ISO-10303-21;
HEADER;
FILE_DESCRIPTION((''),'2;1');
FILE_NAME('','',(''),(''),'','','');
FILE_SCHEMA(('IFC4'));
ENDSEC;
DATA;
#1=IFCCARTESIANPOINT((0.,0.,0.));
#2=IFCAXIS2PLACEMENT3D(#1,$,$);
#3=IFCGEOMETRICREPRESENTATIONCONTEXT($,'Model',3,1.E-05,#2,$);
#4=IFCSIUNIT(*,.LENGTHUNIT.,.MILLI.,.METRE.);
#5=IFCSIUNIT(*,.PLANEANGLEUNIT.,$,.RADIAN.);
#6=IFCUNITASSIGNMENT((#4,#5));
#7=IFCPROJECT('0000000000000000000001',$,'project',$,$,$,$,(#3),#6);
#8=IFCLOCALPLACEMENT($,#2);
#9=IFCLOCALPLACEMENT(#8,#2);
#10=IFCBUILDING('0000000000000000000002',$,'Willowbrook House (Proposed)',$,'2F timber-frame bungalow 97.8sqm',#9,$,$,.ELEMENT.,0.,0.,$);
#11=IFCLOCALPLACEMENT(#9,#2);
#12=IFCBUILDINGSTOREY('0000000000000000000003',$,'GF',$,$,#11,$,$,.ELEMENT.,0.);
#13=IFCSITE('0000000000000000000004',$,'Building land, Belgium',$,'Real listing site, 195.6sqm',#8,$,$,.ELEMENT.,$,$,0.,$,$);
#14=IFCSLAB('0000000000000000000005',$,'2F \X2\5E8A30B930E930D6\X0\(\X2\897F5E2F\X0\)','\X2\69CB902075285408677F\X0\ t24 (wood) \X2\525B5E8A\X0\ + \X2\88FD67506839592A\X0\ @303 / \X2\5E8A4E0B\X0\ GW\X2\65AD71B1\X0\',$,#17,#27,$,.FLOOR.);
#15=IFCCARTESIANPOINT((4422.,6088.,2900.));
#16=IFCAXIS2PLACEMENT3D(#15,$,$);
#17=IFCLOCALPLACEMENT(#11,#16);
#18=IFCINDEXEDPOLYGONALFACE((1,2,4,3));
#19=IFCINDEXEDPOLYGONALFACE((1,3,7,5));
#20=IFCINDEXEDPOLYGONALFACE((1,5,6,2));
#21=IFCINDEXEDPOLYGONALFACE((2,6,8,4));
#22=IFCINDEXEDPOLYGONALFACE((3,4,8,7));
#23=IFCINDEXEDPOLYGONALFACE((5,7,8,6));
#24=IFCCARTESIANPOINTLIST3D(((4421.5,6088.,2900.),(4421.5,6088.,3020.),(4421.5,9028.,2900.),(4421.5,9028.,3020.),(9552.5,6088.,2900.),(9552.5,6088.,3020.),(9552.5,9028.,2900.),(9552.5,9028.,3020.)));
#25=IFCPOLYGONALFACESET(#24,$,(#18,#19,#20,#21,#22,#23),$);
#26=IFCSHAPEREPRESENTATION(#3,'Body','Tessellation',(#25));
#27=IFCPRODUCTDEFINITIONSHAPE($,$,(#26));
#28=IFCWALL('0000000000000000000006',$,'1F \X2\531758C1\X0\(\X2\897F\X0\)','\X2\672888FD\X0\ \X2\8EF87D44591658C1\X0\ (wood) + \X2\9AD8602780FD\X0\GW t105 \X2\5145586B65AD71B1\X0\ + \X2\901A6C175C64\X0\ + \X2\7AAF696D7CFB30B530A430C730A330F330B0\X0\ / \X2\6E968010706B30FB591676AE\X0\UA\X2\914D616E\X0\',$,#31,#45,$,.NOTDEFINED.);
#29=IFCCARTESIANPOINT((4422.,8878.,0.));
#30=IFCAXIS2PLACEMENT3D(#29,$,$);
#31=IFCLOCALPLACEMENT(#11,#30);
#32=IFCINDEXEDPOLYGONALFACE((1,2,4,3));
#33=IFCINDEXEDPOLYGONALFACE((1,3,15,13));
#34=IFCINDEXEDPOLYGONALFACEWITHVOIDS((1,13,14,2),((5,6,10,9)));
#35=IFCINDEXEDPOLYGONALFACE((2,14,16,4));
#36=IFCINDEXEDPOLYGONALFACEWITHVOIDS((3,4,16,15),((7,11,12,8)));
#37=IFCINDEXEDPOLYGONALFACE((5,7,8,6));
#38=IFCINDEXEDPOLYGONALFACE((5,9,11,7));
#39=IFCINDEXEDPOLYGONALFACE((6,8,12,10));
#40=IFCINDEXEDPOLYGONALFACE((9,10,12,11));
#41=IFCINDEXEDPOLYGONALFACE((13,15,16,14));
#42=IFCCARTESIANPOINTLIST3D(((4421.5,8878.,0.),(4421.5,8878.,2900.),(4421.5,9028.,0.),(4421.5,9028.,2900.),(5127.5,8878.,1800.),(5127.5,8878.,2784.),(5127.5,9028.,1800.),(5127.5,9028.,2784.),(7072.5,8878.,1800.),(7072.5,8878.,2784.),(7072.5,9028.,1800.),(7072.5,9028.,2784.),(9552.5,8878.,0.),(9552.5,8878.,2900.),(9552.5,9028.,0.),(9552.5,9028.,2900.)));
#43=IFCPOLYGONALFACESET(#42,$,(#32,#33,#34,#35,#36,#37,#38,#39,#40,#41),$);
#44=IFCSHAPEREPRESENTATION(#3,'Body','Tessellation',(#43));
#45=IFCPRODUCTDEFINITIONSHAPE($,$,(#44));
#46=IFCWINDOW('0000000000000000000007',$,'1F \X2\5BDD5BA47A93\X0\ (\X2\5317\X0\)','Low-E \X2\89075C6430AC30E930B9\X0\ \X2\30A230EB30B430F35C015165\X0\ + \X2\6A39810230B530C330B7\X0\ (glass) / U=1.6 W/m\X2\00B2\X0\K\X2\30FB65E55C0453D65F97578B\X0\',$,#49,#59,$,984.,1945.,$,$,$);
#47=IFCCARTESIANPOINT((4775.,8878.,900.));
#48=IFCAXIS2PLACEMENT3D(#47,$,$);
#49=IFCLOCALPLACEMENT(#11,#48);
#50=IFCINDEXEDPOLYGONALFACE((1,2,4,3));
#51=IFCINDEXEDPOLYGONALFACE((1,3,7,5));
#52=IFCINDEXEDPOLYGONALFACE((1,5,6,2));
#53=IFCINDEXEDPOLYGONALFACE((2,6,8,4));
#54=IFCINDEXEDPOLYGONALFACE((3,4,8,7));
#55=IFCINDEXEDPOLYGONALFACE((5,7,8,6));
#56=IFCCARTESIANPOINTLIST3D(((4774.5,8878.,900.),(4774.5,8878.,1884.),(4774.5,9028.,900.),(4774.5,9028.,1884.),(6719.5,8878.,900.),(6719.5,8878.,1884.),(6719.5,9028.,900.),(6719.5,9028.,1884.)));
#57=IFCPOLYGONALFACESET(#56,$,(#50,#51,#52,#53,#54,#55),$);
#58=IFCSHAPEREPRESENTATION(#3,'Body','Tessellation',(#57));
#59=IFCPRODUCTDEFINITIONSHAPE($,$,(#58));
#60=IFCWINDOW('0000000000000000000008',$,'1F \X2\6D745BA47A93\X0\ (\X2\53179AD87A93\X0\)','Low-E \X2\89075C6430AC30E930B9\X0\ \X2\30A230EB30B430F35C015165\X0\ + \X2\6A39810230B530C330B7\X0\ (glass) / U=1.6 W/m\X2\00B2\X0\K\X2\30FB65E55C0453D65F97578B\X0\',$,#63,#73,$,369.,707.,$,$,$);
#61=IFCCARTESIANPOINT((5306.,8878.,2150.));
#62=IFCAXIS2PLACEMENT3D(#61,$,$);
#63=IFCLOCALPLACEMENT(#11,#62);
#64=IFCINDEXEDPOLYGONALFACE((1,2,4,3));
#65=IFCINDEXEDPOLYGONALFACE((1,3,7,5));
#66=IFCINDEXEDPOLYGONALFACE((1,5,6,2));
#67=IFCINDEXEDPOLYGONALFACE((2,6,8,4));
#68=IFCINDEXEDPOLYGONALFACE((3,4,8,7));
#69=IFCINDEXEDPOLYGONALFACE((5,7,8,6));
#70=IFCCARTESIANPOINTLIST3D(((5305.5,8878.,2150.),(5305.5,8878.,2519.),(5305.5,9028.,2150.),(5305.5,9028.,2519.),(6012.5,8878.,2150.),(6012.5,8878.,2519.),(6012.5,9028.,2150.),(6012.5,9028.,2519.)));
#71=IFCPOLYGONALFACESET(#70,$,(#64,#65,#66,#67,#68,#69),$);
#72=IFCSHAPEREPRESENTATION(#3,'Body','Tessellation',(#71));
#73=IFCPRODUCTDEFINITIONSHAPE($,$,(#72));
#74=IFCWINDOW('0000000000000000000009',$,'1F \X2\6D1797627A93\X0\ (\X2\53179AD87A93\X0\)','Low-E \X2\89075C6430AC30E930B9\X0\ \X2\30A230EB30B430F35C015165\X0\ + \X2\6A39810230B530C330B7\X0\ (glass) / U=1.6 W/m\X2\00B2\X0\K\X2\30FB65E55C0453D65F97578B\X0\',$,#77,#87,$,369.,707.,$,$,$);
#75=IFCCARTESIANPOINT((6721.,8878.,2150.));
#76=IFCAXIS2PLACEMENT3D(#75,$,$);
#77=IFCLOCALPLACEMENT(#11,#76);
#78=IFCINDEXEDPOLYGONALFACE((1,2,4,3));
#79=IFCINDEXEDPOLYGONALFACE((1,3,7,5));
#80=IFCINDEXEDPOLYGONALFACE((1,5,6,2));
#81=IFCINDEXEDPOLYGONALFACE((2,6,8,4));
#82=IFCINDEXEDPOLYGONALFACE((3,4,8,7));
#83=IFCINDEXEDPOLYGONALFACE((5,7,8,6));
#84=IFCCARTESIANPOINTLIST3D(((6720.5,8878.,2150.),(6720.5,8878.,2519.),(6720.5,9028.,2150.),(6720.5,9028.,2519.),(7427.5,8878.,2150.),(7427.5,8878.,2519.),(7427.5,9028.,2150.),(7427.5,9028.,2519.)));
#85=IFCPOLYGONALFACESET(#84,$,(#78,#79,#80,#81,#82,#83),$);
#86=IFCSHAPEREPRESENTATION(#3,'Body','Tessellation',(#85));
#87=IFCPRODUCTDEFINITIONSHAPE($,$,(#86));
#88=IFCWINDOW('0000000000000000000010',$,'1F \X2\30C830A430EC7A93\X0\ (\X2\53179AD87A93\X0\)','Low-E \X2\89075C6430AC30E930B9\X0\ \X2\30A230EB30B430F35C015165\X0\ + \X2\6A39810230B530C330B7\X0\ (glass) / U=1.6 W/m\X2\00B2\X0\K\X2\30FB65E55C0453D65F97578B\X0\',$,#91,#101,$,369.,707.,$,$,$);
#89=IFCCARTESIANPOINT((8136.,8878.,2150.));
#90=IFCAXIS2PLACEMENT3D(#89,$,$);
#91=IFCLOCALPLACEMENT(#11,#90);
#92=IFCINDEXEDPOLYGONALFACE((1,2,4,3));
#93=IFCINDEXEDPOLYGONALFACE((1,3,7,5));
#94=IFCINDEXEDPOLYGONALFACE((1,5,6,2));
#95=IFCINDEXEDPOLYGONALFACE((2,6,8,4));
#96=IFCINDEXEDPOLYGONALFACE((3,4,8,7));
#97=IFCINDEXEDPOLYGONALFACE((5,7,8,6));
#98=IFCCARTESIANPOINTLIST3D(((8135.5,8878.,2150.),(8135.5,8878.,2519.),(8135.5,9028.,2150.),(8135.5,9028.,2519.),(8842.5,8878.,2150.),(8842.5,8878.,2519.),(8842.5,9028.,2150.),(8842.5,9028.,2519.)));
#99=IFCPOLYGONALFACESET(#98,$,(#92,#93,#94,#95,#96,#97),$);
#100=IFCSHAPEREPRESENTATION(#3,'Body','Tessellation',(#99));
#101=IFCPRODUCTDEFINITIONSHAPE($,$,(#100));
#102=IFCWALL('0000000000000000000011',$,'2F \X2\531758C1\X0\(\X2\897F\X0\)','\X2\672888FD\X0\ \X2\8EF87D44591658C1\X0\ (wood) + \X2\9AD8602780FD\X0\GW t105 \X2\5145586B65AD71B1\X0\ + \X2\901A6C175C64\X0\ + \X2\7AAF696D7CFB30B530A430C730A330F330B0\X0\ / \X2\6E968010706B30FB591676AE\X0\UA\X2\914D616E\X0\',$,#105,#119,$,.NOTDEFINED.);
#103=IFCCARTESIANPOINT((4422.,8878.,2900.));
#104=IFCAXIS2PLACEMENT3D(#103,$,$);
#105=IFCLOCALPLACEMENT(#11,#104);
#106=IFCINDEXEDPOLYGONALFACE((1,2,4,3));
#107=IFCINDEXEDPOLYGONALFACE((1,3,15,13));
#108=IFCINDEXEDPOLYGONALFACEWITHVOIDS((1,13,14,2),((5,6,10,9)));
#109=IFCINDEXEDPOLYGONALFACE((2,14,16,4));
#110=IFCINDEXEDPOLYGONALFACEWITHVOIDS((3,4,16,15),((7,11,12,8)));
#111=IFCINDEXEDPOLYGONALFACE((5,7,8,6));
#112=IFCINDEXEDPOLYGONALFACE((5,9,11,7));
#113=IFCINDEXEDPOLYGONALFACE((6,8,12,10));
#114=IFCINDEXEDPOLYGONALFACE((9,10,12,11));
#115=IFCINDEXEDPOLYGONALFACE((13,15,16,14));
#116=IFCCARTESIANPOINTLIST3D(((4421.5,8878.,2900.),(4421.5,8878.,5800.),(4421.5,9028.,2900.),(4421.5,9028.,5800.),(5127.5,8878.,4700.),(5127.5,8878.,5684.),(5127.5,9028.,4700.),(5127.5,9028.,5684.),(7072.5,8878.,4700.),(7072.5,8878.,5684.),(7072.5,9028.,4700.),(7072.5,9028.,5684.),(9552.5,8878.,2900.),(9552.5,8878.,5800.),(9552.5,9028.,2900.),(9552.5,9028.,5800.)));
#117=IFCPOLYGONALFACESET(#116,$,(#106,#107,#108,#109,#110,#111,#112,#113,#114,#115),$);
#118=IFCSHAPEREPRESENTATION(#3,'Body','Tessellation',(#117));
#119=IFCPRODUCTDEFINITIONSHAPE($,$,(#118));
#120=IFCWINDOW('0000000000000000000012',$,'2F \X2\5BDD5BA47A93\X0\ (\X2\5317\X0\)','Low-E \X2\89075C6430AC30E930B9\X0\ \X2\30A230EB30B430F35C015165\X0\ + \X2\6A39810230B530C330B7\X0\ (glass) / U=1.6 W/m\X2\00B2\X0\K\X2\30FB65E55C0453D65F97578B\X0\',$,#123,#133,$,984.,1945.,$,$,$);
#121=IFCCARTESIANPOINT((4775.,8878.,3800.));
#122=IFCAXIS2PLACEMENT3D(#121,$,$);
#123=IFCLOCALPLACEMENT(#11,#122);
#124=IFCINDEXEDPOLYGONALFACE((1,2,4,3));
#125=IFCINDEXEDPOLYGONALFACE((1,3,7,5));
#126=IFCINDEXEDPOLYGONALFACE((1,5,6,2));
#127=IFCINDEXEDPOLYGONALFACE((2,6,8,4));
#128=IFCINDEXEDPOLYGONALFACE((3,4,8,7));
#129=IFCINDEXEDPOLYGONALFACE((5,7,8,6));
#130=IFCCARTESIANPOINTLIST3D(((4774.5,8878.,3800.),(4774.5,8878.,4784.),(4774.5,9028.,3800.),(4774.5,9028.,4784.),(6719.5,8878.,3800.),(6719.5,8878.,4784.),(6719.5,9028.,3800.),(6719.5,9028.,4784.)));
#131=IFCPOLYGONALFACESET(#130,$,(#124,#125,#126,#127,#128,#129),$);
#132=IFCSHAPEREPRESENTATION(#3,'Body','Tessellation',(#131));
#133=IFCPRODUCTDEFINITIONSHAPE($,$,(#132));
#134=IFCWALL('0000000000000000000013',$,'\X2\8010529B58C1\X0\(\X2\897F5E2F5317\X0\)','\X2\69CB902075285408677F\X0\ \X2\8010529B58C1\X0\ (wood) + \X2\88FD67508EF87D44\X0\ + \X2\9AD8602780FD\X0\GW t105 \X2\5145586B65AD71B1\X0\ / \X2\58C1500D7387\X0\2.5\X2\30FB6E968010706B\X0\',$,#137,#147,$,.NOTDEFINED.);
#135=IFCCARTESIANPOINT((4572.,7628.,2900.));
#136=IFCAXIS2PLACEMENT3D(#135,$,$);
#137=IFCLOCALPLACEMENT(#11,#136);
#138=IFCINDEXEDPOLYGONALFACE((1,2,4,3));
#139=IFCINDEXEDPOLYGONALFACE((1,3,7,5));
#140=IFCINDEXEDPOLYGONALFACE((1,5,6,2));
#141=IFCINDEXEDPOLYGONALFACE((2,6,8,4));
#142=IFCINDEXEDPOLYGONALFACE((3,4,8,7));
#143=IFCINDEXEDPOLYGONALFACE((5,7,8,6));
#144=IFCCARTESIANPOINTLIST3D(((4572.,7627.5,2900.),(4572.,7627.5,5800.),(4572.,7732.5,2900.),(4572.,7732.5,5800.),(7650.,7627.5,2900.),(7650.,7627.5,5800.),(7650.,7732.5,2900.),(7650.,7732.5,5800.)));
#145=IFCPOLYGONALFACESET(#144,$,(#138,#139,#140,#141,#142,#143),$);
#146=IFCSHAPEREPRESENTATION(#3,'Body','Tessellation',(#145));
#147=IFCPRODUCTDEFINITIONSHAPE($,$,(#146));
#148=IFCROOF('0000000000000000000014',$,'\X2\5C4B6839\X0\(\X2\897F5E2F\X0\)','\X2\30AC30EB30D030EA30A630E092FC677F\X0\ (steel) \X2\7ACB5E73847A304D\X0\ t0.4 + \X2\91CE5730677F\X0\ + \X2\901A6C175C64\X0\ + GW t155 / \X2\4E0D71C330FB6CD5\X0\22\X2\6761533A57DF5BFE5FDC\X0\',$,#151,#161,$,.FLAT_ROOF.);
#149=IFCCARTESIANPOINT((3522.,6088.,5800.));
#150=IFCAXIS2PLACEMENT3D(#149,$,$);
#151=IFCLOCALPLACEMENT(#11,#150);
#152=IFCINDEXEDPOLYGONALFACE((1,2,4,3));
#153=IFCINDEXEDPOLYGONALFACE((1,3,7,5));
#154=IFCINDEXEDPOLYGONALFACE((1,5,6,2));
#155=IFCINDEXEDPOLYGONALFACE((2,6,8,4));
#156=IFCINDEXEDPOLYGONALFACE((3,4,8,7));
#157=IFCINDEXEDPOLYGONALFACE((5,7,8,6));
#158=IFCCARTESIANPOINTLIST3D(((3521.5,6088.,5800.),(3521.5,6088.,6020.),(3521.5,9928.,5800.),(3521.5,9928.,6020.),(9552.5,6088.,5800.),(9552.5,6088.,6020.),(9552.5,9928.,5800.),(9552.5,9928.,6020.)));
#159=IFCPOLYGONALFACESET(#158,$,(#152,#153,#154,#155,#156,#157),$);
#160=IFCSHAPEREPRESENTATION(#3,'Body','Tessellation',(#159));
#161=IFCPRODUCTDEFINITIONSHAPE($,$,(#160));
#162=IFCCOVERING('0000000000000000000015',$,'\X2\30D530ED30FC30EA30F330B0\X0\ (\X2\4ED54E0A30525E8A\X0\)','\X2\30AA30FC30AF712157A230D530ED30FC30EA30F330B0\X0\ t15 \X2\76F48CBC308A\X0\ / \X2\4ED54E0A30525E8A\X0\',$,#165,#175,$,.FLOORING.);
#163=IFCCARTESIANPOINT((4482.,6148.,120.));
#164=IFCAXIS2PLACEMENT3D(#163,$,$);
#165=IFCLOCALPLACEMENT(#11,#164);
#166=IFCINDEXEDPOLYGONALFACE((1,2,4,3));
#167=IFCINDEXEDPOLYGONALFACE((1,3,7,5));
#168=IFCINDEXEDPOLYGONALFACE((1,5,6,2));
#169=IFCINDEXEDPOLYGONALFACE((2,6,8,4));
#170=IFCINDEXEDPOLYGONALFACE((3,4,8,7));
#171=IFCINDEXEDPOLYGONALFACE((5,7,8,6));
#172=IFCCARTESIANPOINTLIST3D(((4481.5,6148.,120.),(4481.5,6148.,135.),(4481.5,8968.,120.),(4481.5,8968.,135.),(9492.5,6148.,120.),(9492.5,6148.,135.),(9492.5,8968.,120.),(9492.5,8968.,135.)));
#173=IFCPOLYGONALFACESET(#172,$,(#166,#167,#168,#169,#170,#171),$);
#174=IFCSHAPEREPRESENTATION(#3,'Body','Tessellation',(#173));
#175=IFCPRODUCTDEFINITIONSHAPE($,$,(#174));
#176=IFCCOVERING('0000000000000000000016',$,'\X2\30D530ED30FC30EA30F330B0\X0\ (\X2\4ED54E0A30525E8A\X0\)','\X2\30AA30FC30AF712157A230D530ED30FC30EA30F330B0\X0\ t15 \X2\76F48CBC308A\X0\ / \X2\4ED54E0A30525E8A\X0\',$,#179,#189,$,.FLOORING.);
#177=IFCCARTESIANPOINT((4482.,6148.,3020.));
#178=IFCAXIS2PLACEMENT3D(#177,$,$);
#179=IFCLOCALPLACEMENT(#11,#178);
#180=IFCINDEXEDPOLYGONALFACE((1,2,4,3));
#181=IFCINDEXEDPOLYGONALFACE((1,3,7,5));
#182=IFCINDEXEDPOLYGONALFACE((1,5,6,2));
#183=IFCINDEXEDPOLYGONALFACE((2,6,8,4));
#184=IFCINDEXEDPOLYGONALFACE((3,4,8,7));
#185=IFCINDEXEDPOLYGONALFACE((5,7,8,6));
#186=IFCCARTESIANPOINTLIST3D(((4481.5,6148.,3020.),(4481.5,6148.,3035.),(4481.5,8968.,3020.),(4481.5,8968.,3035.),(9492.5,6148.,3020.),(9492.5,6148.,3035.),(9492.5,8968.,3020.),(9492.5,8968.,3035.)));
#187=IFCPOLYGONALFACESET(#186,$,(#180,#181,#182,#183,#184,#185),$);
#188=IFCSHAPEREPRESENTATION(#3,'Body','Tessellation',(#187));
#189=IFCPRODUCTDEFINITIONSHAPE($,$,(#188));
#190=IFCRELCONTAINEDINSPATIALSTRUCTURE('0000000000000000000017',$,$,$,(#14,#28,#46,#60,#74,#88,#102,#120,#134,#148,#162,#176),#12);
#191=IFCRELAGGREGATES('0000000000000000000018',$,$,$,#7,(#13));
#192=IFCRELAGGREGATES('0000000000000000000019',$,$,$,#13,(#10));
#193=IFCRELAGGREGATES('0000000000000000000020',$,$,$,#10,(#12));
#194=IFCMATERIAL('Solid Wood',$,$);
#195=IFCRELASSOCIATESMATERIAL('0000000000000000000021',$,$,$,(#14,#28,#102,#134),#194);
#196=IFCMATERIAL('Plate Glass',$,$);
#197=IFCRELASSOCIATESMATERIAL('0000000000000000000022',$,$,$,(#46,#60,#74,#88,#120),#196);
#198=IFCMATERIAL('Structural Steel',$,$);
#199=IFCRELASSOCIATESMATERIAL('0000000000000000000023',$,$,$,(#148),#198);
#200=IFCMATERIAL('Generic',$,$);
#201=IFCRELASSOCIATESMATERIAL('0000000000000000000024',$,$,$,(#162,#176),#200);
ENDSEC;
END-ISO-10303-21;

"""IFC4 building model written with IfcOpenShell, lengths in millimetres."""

from ifc_helpers import new_model, si_unit, frame, frame_2d, origin, place, context, project, spatial, rectangle, extrude, material, element, fill, save


model = new_model("IFC4")

# Units and contexts
model_context = context("Model", 3, precision=1e-05, world=origin())
ifc_project = project(units=[si_unit("LENGTHUNIT", "METRE", prefix="MILLI"), si_unit("PLANEANGLEUNIT", "RADIAN")], contexts=[model_context])

# Site, building, storey
site_placement = place(None, origin())
site = spatial("IfcSite", under=ifc_project, at=site_placement, Name="Building land, Belgium", ObjectType="Real listing site, 195.6sqm", CompositionType="ELEMENT", RefElevation=0.0)
building_placement = place(site_placement, origin())
building = spatial("IfcBuilding", under=site, at=building_placement, Name="Willowbrook House (Proposed)", ObjectType="2F timber-frame bungalow 97.8sqm", CompositionType="ELEMENT", ElevationOfRefHeight=0.0, ElevationOfTerrain=0.0)
storey_placement = place(building_placement, origin())
storey = spatial("IfcBuildingStorey", under=building, at=storey_placement, Name="GF", CompositionType="ELEMENT", Elevation=0.0)

# Slab
ifc_material_1 = material(Name="Solid Wood")
slab_1_placement = place(storey_placement, frame((4422.0, 6088.0, 2900.0)))
element("IfcSlab", 1, at=slab_1_placement, inside=storey, material=ifc_material_1, Name="2F 床スラブ(西帯)", Description="構造用合板 t24 (wood) 剛床 + 製材根太 @303 / 床下 GW断熱", PredefinedType="FLOOR", context=model_context, shape_type="SweptSolid", body=[
    extrude(rectangle(XDim=5131.0, YDim=2940.0, at=frame_2d((2565.0, 1470.0))), frame((4422.0, 6088.0, 2900.0)), (0.0, 0.0, 1.0), 120.0),
])

# Wall, openings, windows
wall_1_placement = place(storey_placement, frame((4422.0, 8878.0, 0.0)))
wall_1 = element("IfcWall", 2, at=wall_1_placement, inside=storey, material=ifc_material_1, Name="1F 北壁(西)", Description="木製 軸組外壁 (wood) + 高性能GW t105 充填断熱 + 通気層 + 窯業系サイディング / 準耐火・外皮UA配慮", PredefinedType="NOTDEFINED", context=model_context, shape_type="SweptSolid", body=[
    extrude(rectangle(XDim=5131.0, YDim=150.0, at=frame_2d((2565.0, 75.0))), frame((4422.0, 8878.0, 0.0)), (0.0, 0.0, 1.0), 2900.0),
])
opening_1_placement = place(storey_placement, frame((4775.0, 8878.0, 900.0)))
opening_1 = element("IfcOpeningElement", 3, at=opening_1_placement, cuts=wall_1, PredefinedType="NOTDEFINED", context=model_context, shape_type="SweptSolid", body=[
    extrude(rectangle(XDim=1945.0, YDim=150.0, at=frame_2d((972.0, 75.0))), frame((4775.0, 8878.0, 900.0)), (0.0, 0.0, 1.0), 984.0),
])
opening_2_placement = place(storey_placement, frame((5306.0, 8878.0, 2150.0)))
opening_2 = element("IfcOpeningElement", 4, at=opening_2_placement, cuts=wall_1, PredefinedType="NOTDEFINED", context=model_context, shape_type="SweptSolid", body=[
    extrude(rectangle(XDim=707.0, YDim=150.0, at=frame_2d((353.0, 75.0))), frame((5306.0, 8878.0, 2150.0)), (0.0, 0.0, 1.0), 369.0),
])
opening_3_placement = place(storey_placement, frame((6721.0, 8878.0, 2150.0)))
opening_3 = element("IfcOpeningElement", 5, at=opening_3_placement, cuts=wall_1, PredefinedType="NOTDEFINED", context=model_context, shape_type="SweptSolid", body=[
    extrude(rectangle(XDim=707.0, YDim=150.0, at=frame_2d((353.0, 75.0))), frame((6721.0, 8878.0, 2150.0)), (0.0, 0.0, 1.0), 369.0),
])
opening_4_placement = place(storey_placement, frame((8136.0, 8878.0, 2150.0)))
opening_4 = element("IfcOpeningElement", 6, at=opening_4_placement, cuts=wall_1, PredefinedType="NOTDEFINED", context=model_context, shape_type="SweptSolid", body=[
    extrude(rectangle(XDim=707.0, YDim=150.0, at=frame_2d((353.0, 75.0))), frame((8136.0, 8878.0, 2150.0)), (0.0, 0.0, 1.0), 369.0),
])
ifc_material_2 = material(Name="Plate Glass")
window_1_placement = place(storey_placement, frame((4775.0, 8878.0, 900.0)))
window_1 = element("IfcWindow", 7, at=window_1_placement, inside=storey, material=ifc_material_2, Name="1F 寝室窓 (北)", Description="Low-E 複層ガラス アルゴン封入 + 樹脂サッシ (glass) / U=1.6 W/m²K・日射取得型", OverallHeight=984.0, OverallWidth=1945.0, context=model_context, shape_type="SweptSolid", body=[
    extrude(rectangle(XDim=1945.0, YDim=150.0, at=frame_2d((972.0, 75.0))), frame((4775.0, 8878.0, 900.0)), (0.0, 0.0, 1.0), 984.0),
])
fill(opening_1, window_1)
window_2_placement = place(storey_placement, frame((5306.0, 8878.0, 2150.0)))
window_2 = element("IfcWindow", 8, at=window_2_placement, inside=storey, material=ifc_material_2, Name="1F 浴室窓 (北高窓)", Description="Low-E 複層ガラス アルゴン封入 + 樹脂サッシ (glass) / U=1.6 W/m²K・日射取得型", OverallHeight=369.0, OverallWidth=707.0, context=model_context, shape_type="SweptSolid", body=[
    extrude(rectangle(XDim=707.0, YDim=150.0, at=frame_2d((353.0, 75.0))), frame((5306.0, 8878.0, 2150.0)), (0.0, 0.0, 1.0), 369.0),
])
fill(opening_2, window_2)
window_3_placement = place(storey_placement, frame((6721.0, 8878.0, 2150.0)))
window_3 = element("IfcWindow", 9, at=window_3_placement, inside=storey, material=ifc_material_2, Name="1F 洗面窓 (北高窓)", Description="Low-E 複層ガラス アルゴン封入 + 樹脂サッシ (glass) / U=1.6 W/m²K・日射取得型", OverallHeight=369.0, OverallWidth=707.0, context=model_context, shape_type="SweptSolid", body=[
    extrude(rectangle(XDim=707.0, YDim=150.0, at=frame_2d((353.0, 75.0))), frame((6721.0, 8878.0, 2150.0)), (0.0, 0.0, 1.0), 369.0),
])
fill(opening_3, window_3)
window_4_placement = place(storey_placement, frame((8136.0, 8878.0, 2150.0)))
window_4 = element("IfcWindow", 10, at=window_4_placement, inside=storey, material=ifc_material_2, Name="1F トイレ窓 (北高窓)", Description="Low-E 複層ガラス アルゴン封入 + 樹脂サッシ (glass) / U=1.6 W/m²K・日射取得型", OverallHeight=369.0, OverallWidth=707.0, context=model_context, shape_type="SweptSolid", body=[
    extrude(rectangle(XDim=707.0, YDim=150.0, at=frame_2d((353.0, 75.0))), frame((8136.0, 8878.0, 2150.0)), (0.0, 0.0, 1.0), 369.0),
])
fill(opening_4, window_4)

# Wall, opening, window
wall_2_placement = place(storey_placement, frame((4422.0, 8878.0, 2900.0)))
wall_2 = element("IfcWall", 11, at=wall_2_placement, inside=storey, material=ifc_material_1, Name="2F 北壁(西)", Description="木製 軸組外壁 (wood) + 高性能GW t105 充填断熱 + 通気層 + 窯業系サイディング / 準耐火・外皮UA配慮", PredefinedType="NOTDEFINED", context=model_context, shape_type="SweptSolid", body=[
    extrude(rectangle(XDim=5131.0, YDim=150.0, at=frame_2d((2565.0, 75.0))), frame((4422.0, 8878.0, 2900.0)), (0.0, 0.0, 1.0), 2900.0),
])
opening_5_placement = place(storey_placement, frame((4775.0, 8878.0, 3800.0)))
opening_5 = element("IfcOpeningElement", 12, at=opening_5_placement, cuts=wall_2, PredefinedType="NOTDEFINED", context=model_context, shape_type="SweptSolid", body=[
    extrude(rectangle(XDim=1945.0, YDim=150.0, at=frame_2d((972.0, 75.0))), frame((4775.0, 8878.0, 3800.0)), (0.0, 0.0, 1.0), 984.0),
])
window_5_placement = place(storey_placement, frame((4775.0, 8878.0, 3800.0)))
window_5 = element("IfcWindow", 13, at=window_5_placement, inside=storey, material=ifc_material_2, Name="2F 寝室窓 (北)", Description="Low-E 複層ガラス アルゴン封入 + 樹脂サッシ (glass) / U=1.6 W/m²K・日射取得型", OverallHeight=984.0, OverallWidth=1945.0, context=model_context, shape_type="SweptSolid", body=[
    extrude(rectangle(XDim=1945.0, YDim=150.0, at=frame_2d((972.0, 75.0))), frame((4775.0, 8878.0, 3800.0)), (0.0, 0.0, 1.0), 984.0),
])
fill(opening_5, window_5)

# Wall
wall_3_placement = place(storey_placement, frame((4572.0, 7628.0, 2900.0)))
element("IfcWall", 14, at=wall_3_placement, inside=storey, material=ifc_material_1, Name="耐力壁(西帯北)", Description="構造用合板 耐力壁 (wood) + 製材軸組 + 高性能GW t105 充填断熱 / 壁倍率2.5・準耐火", PredefinedType="NOTDEFINED", context=model_context, shape_type="SweptSolid", body=[
    extrude(rectangle(XDim=3078.0, YDim=105.0, at=frame_2d((1539.0, 52.0))), frame((4572.0, 7628.0, 2900.0)), (0.0, 0.0, 1.0), 2900.0),
])

# Roof
ifc_material_3 = material(Name="Structural Steel")
for number, where, name in (
    (15, (3522.0, 6088.0, 5800.0), "屋根(西帯)"),
):
    element("IfcRoof", number, at=place(storey_placement, frame(where)), inside=storey, material=ifc_material_3, Name=name, Description="ガルバリウム鋼板 (steel) 立平葺き t0.4 + 野地板 + 通気層 + GW t155 / 不燃・法22条区域対応", PredefinedType="FLAT_ROOF", context=model_context, shape_type="SweptSolid", body=[
        extrude(rectangle(XDim=6031.0, YDim=3840.0, at=frame_2d((3015.0, 1920.0))), frame((3522.0, 6088.0, 5800.0)), (0.0, 0.0, 1.0), 220.0),
    ])

# Coverings
ifc_material_4 = material(Name="Generic")
covering_1_placement = place(storey_placement, frame((4482.0, 6148.0, 120.0)))
element("IfcCovering", 16, at=covering_1_placement, inside=storey, material=ifc_material_4, Name="フローリング (仕上げ床)", Description="オーク無垢フローリング t15 直貼り / 仕上げ床", PredefinedType="FLOORING", context=model_context, shape_type="SweptSolid", body=[
    extrude(rectangle(XDim=5011.0, YDim=2820.0, at=frame_2d((2505.0, 1410.0))), frame((4482.0, 6148.0, 120.0)), (0.0, 0.0, 1.0), 15.0),
])
covering_2_placement = place(storey_placement, frame((4482.0, 6148.0, 3020.0)))
element("IfcCovering", 17, at=covering_2_placement, inside=storey, material=ifc_material_4, Name="フローリング (仕上げ床)", Description="オーク無垢フローリング t15 直貼り / 仕上げ床", PredefinedType="FLOORING", context=model_context, shape_type="SweptSolid", body=[
    extrude(rectangle(XDim=5011.0, YDim=2820.0, at=frame_2d((2505.0, 1410.0))), frame((4482.0, 6148.0, 3020.0)), (0.0, 0.0, 1.0), 15.0),
])

save(model, "model.ifc")
